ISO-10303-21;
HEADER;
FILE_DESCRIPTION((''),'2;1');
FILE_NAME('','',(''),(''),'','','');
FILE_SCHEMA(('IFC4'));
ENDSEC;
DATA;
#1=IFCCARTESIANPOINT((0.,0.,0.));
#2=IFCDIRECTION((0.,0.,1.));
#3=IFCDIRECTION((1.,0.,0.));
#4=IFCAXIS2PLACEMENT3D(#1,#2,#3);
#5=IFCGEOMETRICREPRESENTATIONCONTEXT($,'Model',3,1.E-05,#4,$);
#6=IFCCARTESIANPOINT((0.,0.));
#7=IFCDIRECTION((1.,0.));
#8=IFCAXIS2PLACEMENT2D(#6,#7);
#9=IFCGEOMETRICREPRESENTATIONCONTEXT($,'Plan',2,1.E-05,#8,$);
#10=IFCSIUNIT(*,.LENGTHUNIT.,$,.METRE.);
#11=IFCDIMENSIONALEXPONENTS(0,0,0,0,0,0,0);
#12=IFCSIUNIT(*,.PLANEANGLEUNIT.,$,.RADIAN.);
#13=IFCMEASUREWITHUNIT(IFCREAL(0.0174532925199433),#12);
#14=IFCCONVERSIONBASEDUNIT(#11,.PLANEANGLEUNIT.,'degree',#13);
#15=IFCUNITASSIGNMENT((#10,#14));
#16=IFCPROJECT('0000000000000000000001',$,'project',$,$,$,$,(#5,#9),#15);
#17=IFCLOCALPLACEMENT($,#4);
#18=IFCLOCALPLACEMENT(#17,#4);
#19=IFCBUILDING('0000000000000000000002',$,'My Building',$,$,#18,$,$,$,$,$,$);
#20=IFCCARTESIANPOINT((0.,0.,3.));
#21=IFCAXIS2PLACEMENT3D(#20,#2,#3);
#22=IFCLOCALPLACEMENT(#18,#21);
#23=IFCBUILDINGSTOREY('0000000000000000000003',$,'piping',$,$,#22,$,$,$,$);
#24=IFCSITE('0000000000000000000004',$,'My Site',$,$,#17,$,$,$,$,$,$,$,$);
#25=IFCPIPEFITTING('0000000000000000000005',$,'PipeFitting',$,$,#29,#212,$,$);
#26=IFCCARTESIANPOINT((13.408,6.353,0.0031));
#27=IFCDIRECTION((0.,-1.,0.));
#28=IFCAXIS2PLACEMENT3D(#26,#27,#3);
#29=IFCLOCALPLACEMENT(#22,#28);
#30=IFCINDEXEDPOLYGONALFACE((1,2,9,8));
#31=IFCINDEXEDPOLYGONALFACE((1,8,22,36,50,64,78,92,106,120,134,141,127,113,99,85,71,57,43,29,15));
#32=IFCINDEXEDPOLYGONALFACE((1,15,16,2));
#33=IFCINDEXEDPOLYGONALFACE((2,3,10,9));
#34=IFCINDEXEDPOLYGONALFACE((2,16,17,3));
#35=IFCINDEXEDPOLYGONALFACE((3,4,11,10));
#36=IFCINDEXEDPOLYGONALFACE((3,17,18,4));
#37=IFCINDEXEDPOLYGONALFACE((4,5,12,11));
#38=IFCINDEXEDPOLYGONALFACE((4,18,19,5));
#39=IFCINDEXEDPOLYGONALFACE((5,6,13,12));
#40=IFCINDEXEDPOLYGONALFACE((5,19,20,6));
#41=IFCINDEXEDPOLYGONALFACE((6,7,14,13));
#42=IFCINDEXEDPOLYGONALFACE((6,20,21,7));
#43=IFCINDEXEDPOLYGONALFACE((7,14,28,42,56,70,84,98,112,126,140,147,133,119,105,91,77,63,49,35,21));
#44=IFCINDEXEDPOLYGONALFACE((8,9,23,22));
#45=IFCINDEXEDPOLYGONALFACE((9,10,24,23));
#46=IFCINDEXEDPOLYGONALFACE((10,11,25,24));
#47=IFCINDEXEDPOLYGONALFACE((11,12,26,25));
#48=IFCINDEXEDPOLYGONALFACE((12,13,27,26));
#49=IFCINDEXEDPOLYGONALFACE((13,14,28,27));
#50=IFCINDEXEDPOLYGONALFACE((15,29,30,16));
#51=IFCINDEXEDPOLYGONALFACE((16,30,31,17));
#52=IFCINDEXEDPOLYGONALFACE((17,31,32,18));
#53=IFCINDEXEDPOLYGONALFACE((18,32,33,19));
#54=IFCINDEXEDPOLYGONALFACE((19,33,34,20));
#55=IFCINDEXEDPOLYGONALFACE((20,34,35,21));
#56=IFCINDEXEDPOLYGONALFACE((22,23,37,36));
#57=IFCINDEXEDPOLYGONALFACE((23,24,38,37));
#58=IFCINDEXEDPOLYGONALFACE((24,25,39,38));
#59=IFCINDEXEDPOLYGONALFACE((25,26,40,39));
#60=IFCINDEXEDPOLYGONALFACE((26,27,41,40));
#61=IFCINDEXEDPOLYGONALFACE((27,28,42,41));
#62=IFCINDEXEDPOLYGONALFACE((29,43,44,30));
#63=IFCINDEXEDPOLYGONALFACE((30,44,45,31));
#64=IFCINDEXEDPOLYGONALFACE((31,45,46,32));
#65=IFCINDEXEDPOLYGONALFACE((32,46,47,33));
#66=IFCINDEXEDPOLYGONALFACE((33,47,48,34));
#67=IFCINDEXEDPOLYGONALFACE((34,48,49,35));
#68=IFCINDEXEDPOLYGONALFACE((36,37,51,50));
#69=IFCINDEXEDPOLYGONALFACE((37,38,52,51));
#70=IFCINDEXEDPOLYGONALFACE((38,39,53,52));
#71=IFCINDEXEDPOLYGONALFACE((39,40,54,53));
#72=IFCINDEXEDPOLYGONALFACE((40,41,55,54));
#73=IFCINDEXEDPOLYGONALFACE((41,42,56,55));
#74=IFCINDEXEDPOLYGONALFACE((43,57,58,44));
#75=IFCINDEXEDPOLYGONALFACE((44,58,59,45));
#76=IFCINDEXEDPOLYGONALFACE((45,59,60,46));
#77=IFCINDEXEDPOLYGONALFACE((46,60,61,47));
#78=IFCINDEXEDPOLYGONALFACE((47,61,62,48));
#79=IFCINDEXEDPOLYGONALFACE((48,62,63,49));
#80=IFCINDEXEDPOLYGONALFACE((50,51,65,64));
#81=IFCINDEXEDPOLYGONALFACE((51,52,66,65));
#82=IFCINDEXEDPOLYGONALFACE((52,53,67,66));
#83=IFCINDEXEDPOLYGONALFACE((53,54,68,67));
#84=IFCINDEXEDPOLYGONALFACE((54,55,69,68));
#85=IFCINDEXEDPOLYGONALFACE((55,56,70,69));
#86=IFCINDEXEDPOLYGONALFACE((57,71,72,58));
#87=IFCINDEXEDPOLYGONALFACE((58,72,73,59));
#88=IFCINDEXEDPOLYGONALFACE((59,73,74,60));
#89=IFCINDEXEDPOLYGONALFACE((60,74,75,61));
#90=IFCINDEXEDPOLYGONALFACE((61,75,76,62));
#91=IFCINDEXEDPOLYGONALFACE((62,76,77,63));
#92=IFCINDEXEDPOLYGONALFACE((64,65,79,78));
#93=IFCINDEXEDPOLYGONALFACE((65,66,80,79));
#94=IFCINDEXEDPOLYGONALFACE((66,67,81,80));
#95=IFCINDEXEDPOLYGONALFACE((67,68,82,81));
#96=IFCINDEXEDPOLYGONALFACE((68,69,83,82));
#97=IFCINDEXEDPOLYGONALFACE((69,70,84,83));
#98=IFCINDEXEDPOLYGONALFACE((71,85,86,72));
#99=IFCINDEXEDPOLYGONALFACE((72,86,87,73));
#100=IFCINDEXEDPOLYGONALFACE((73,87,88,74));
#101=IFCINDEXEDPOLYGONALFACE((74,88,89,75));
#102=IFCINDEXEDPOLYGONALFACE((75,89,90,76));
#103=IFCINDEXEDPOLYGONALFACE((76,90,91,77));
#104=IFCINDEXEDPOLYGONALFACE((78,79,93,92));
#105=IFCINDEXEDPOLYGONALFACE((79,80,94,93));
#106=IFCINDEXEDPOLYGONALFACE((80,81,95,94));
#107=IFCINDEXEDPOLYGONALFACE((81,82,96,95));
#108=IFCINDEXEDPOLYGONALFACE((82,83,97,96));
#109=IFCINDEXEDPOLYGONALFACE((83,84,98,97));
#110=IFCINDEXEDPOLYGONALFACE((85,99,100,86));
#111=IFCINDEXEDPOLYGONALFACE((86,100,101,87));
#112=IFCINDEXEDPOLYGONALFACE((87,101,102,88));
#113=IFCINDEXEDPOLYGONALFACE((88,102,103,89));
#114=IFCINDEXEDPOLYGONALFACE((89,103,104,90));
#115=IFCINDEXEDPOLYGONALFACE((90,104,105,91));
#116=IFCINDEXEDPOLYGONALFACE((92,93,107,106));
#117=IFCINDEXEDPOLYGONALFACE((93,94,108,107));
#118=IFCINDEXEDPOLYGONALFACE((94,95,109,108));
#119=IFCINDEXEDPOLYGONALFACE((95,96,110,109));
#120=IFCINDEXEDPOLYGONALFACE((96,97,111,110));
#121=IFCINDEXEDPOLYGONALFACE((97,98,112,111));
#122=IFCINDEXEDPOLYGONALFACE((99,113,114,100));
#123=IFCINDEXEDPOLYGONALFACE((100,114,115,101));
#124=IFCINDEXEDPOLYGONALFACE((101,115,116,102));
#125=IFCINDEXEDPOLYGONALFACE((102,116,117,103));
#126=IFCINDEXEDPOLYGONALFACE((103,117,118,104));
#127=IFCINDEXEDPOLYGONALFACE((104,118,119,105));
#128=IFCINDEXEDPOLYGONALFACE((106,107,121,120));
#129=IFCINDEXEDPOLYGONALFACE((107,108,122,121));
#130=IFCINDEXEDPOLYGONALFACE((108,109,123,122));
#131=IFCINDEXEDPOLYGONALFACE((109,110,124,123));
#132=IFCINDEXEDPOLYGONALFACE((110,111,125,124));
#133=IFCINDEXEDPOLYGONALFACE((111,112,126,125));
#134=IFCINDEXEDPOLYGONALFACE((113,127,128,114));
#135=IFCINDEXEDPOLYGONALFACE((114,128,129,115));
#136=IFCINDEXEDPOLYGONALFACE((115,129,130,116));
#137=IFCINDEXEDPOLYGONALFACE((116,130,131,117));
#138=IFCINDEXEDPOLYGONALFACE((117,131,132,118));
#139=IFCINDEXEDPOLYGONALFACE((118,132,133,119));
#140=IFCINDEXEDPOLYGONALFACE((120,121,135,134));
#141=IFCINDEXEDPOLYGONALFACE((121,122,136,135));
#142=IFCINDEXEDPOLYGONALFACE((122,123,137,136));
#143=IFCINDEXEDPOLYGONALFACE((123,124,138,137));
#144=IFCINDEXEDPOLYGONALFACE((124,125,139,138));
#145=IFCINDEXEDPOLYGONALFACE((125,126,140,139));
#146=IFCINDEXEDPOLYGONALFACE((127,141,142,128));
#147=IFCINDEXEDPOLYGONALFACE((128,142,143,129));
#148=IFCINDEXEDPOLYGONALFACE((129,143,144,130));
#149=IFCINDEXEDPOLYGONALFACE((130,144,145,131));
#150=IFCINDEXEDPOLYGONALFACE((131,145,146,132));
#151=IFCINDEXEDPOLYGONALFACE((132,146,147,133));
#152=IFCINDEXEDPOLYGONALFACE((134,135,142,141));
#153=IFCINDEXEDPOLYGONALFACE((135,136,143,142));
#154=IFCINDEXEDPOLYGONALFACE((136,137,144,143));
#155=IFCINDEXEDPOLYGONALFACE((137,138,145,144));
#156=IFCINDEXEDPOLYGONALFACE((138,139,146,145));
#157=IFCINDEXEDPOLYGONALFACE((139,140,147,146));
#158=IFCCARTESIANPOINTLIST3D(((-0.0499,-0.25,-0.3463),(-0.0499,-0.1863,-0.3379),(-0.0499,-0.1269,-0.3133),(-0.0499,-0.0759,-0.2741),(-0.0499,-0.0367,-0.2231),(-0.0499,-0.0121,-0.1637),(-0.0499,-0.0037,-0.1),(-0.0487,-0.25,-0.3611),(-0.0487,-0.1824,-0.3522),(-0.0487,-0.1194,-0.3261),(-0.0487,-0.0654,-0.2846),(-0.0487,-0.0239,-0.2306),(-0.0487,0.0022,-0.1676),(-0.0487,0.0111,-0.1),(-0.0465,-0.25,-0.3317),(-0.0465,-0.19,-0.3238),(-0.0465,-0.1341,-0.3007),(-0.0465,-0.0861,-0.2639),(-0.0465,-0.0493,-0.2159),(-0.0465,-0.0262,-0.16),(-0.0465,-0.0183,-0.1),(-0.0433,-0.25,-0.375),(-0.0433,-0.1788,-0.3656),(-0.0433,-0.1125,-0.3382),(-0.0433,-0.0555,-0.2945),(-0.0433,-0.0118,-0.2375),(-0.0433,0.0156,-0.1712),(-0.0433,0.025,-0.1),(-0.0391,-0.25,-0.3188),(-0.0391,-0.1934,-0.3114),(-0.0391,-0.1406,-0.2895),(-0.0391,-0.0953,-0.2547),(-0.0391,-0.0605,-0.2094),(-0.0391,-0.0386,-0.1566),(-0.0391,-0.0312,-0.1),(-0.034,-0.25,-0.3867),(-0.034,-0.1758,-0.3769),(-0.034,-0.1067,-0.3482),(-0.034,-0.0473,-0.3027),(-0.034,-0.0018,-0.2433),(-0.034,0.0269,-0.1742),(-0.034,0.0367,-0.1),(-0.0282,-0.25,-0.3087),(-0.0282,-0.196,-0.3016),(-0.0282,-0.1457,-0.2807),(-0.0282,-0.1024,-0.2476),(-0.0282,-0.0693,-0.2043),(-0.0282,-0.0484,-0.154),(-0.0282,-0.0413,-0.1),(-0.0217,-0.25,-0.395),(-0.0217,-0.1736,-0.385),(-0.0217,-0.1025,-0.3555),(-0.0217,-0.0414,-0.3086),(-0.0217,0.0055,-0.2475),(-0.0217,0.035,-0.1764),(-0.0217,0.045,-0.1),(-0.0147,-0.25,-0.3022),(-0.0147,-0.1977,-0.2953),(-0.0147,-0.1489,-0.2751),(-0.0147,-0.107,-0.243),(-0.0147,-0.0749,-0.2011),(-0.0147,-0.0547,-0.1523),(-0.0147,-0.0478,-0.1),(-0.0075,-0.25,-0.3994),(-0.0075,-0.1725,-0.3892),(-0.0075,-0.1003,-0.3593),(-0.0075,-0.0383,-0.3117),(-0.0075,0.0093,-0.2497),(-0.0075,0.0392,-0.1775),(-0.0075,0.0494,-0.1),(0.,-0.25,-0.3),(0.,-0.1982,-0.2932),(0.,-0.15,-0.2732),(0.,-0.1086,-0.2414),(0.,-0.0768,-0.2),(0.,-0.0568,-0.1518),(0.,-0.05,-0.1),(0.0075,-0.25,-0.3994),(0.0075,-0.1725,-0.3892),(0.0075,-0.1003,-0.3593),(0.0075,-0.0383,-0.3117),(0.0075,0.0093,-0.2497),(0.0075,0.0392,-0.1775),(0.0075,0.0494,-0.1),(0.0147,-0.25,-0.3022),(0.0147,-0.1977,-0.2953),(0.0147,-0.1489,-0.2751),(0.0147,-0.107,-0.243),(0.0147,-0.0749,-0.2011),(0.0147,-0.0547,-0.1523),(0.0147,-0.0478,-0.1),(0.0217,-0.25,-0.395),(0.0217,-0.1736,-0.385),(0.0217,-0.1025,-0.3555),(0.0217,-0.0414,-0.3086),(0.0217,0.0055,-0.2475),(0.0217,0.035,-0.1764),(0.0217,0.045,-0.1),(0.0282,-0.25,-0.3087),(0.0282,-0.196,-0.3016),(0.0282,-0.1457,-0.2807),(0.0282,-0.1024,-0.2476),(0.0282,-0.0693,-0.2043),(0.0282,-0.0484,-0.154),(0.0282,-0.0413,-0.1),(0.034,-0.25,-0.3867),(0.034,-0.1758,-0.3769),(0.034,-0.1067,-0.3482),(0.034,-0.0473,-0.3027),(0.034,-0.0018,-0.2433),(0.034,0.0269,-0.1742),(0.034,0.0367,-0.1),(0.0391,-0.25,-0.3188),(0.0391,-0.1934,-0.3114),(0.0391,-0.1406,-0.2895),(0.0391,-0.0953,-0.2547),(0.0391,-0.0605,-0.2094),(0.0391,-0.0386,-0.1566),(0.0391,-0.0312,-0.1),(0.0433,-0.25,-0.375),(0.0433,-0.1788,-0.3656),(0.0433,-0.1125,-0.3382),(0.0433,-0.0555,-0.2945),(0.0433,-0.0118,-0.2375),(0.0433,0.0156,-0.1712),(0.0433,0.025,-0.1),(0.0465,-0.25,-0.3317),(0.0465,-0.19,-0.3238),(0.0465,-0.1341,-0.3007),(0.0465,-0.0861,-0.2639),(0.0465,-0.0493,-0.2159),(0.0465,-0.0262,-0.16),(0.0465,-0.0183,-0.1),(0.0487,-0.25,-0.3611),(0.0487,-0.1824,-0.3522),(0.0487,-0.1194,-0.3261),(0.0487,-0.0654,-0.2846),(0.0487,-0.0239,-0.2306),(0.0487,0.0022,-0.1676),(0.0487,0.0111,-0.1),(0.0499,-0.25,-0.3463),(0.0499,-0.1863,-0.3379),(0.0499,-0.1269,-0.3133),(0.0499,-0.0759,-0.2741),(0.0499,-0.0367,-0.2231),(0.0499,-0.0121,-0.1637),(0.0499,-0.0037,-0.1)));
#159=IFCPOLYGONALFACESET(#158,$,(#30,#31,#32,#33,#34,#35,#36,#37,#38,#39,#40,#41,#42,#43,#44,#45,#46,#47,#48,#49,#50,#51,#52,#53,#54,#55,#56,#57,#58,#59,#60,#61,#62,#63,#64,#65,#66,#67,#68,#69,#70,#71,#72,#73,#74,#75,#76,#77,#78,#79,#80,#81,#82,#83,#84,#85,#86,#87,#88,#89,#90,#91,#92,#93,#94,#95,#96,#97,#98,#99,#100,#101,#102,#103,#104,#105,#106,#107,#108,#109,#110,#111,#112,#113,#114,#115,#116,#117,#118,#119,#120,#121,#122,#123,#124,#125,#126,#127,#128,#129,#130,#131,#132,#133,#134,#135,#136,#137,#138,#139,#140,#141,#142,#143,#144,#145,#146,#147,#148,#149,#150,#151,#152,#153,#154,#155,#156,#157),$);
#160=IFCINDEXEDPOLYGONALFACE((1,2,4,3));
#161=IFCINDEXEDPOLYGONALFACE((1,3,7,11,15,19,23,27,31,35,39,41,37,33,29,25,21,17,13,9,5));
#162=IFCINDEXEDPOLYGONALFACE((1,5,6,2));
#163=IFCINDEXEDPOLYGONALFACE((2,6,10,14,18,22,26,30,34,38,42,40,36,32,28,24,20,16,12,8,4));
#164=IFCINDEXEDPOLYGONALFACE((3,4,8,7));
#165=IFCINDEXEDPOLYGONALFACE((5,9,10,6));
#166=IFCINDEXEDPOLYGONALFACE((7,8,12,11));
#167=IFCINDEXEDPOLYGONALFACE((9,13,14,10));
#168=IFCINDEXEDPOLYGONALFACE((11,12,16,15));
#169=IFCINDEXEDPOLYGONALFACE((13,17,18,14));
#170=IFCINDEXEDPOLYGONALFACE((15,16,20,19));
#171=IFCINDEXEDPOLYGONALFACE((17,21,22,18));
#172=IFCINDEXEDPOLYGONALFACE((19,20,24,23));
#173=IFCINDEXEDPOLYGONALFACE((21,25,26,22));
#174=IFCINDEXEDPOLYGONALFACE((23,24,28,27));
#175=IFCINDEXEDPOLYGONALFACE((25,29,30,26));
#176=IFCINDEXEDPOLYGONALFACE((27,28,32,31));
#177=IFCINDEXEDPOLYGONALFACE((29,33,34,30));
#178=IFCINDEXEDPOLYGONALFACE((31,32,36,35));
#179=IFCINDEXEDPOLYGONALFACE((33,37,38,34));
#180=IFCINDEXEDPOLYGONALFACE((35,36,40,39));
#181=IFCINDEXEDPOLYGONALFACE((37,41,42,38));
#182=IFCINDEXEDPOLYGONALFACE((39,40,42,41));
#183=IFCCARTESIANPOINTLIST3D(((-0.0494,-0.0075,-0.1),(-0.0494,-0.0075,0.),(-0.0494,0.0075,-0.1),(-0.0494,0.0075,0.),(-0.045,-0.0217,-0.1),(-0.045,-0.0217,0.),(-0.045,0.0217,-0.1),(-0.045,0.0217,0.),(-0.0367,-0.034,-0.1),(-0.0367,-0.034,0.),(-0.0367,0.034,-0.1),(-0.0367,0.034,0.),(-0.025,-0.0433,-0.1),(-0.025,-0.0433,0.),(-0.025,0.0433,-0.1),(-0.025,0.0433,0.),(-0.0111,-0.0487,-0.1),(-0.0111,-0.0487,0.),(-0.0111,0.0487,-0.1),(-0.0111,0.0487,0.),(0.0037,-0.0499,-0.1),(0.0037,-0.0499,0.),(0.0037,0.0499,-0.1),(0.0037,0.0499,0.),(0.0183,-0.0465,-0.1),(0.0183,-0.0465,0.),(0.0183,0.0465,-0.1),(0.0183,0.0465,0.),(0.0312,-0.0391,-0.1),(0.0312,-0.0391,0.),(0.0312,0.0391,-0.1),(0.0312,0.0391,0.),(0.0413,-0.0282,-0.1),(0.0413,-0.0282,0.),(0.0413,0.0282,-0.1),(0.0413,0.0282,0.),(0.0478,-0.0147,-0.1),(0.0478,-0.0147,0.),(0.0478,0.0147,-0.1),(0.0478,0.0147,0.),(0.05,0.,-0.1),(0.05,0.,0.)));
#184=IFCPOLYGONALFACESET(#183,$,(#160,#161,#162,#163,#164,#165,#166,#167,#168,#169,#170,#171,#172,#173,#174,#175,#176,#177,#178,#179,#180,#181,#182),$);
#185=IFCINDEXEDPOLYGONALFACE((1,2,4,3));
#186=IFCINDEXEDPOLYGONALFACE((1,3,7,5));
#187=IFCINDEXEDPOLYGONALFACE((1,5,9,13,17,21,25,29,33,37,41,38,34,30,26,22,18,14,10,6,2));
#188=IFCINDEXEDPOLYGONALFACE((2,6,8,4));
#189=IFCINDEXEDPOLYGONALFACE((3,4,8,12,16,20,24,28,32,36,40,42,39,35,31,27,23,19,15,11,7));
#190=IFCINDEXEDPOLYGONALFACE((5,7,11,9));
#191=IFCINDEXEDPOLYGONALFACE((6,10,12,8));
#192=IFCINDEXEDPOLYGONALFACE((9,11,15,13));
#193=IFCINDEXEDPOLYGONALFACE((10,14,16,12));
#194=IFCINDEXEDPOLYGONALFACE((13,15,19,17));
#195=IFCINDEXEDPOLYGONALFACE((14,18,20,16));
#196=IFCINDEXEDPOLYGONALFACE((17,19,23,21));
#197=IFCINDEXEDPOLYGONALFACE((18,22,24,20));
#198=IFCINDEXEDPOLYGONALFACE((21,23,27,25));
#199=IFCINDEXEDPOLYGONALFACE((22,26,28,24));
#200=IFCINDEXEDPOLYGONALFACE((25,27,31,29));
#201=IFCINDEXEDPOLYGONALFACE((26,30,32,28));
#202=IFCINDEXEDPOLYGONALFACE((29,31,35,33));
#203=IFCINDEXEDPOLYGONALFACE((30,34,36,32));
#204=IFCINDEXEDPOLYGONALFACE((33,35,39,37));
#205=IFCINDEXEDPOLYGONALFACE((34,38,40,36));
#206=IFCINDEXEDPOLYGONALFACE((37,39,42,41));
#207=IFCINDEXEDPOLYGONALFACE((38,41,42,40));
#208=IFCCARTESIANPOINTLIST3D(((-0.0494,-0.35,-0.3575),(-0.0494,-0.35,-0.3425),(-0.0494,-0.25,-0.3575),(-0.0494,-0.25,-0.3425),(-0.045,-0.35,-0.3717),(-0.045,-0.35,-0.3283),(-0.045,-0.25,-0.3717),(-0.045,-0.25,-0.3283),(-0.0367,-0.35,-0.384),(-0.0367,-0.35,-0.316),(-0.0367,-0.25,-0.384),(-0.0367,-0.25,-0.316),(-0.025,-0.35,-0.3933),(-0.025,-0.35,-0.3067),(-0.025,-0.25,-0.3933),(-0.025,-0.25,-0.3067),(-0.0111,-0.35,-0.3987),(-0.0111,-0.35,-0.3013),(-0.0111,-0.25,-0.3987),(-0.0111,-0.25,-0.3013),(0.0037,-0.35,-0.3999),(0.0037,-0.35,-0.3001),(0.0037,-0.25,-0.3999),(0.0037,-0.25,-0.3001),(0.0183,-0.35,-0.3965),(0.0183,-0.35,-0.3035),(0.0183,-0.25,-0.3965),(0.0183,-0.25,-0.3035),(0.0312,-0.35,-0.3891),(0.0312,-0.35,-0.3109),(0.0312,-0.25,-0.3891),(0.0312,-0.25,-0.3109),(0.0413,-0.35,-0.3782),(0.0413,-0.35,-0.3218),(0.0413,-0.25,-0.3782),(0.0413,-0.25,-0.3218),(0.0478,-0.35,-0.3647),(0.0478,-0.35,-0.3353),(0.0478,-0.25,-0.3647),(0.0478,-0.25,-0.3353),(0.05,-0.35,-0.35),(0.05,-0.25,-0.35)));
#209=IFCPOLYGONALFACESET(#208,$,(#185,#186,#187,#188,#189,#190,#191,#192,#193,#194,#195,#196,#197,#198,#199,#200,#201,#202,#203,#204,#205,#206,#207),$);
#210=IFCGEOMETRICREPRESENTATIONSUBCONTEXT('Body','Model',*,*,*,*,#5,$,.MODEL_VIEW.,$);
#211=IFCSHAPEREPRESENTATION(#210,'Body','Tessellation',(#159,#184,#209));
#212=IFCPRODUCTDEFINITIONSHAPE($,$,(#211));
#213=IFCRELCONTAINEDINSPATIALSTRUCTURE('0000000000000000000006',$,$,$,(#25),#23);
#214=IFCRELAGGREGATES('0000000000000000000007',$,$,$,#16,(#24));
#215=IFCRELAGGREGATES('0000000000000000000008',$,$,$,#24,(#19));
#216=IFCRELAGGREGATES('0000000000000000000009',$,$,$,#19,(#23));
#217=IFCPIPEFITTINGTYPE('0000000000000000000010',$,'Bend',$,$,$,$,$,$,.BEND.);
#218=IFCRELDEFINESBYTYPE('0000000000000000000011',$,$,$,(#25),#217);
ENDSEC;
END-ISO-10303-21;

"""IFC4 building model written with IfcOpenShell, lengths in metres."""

from ifc_helpers import new_model, entity, si_unit, converted_unit, frame, origin_with_axes, origin_2d_with_axis, place, context, subcontext, project, spatial, circle, extrude, source, transform, mapped, type_object, type_shapes, element, save


model = new_model("IFC4")

# Units and contexts
model_context = context("Model", 3, precision=1e-05, world=origin_with_axes())
plan_context = context("Plan", 2, precision=1e-05, world=origin_2d_with_axis())
body_context = subcontext(model_context, "Body", "Model", "MODEL_VIEW")
ifc_project = project(units=[si_unit("LENGTHUNIT", "METRE"), converted_unit("PLANEANGLEUNIT", "degree", entity("IfcReal", 0.0174532925199433), si_unit("PLANEANGLEUNIT", "RADIAN"), dimensions=[0, 0, 0, 0, 0, 0, 0])], contexts=[model_context, plan_context])

# Site, building, storey
site_placement = place(None, origin_with_axes())
site = spatial("IfcSite", under=ifc_project, at=site_placement, Name="My Site")
building_placement = place(site_placement, origin_with_axes())
building = spatial("IfcBuilding", under=site, at=building_placement, Name="My Building")
storey_placement = place(building_placement, frame((0.0, 0.0, 3.0), z_axis=(0.0, 0.0, 1.0), x_axis=(1.0, 0.0, 0.0)))
storey = spatial("IfcBuildingStorey", under=building, at=storey_placement, Name="piping")

# Pipe fitting
pipe_fitting_type = type_object("IfcPipeFittingType", Name="Bend", PredefinedType="BEND")
shared_shape = source(origin_with_axes(), body_context, "Body", "SolidModel", [
    entity("IfcSweptDiskSolid", entity("IfcIndexedPolyCurve", entity("IfcCartesianPointList3D", [[0.0, 0.0, -0.1], [0.0, -0.0732, -0.2768], [0.0, -0.25, -0.35]]), [entity("IfcArcIndex", [1, 2, 3])]), 0.05),
    extrude(circle(Radius=0.05), origin_with_axes(), (0.0, 0.0, -1.0), 0.1),
    extrude(circle(Radius=0.05), frame((0.0, -0.25, -0.35), z_axis=(0.0, -1.0, 0.0), x_axis=(1.0, 0.0, 0.0)), (0.0, 0.0, 1.0), 0.1),
])
type_shapes(pipe_fitting_type, [shared_shape])
for number, where, z_axis, x_axis, name in (
    (1, (13.408, 6.353, 0.0031), (0.0, -1.0, 0.0), (1.0, 0.0, 0.0), "PipeFitting"),
):
    element("IfcPipeFitting", number, at=place(storey_placement, frame(where, z_axis=z_axis, x_axis=x_axis)), inside=storey, type_object=pipe_fitting_type, Name=name, context=body_context, shape_type="MappedRepresentation", body=[
        mapped(shared_shape, transform((0.0, 0.0, 0.0), x_axis=(1.0, 0.0, 0.0), y_axis=(0.0, 1.0, 0.0), z_axis=(0.0, 0.0, 1.0), scale=1.0)),
    ])

save(model, "model.ifc")
